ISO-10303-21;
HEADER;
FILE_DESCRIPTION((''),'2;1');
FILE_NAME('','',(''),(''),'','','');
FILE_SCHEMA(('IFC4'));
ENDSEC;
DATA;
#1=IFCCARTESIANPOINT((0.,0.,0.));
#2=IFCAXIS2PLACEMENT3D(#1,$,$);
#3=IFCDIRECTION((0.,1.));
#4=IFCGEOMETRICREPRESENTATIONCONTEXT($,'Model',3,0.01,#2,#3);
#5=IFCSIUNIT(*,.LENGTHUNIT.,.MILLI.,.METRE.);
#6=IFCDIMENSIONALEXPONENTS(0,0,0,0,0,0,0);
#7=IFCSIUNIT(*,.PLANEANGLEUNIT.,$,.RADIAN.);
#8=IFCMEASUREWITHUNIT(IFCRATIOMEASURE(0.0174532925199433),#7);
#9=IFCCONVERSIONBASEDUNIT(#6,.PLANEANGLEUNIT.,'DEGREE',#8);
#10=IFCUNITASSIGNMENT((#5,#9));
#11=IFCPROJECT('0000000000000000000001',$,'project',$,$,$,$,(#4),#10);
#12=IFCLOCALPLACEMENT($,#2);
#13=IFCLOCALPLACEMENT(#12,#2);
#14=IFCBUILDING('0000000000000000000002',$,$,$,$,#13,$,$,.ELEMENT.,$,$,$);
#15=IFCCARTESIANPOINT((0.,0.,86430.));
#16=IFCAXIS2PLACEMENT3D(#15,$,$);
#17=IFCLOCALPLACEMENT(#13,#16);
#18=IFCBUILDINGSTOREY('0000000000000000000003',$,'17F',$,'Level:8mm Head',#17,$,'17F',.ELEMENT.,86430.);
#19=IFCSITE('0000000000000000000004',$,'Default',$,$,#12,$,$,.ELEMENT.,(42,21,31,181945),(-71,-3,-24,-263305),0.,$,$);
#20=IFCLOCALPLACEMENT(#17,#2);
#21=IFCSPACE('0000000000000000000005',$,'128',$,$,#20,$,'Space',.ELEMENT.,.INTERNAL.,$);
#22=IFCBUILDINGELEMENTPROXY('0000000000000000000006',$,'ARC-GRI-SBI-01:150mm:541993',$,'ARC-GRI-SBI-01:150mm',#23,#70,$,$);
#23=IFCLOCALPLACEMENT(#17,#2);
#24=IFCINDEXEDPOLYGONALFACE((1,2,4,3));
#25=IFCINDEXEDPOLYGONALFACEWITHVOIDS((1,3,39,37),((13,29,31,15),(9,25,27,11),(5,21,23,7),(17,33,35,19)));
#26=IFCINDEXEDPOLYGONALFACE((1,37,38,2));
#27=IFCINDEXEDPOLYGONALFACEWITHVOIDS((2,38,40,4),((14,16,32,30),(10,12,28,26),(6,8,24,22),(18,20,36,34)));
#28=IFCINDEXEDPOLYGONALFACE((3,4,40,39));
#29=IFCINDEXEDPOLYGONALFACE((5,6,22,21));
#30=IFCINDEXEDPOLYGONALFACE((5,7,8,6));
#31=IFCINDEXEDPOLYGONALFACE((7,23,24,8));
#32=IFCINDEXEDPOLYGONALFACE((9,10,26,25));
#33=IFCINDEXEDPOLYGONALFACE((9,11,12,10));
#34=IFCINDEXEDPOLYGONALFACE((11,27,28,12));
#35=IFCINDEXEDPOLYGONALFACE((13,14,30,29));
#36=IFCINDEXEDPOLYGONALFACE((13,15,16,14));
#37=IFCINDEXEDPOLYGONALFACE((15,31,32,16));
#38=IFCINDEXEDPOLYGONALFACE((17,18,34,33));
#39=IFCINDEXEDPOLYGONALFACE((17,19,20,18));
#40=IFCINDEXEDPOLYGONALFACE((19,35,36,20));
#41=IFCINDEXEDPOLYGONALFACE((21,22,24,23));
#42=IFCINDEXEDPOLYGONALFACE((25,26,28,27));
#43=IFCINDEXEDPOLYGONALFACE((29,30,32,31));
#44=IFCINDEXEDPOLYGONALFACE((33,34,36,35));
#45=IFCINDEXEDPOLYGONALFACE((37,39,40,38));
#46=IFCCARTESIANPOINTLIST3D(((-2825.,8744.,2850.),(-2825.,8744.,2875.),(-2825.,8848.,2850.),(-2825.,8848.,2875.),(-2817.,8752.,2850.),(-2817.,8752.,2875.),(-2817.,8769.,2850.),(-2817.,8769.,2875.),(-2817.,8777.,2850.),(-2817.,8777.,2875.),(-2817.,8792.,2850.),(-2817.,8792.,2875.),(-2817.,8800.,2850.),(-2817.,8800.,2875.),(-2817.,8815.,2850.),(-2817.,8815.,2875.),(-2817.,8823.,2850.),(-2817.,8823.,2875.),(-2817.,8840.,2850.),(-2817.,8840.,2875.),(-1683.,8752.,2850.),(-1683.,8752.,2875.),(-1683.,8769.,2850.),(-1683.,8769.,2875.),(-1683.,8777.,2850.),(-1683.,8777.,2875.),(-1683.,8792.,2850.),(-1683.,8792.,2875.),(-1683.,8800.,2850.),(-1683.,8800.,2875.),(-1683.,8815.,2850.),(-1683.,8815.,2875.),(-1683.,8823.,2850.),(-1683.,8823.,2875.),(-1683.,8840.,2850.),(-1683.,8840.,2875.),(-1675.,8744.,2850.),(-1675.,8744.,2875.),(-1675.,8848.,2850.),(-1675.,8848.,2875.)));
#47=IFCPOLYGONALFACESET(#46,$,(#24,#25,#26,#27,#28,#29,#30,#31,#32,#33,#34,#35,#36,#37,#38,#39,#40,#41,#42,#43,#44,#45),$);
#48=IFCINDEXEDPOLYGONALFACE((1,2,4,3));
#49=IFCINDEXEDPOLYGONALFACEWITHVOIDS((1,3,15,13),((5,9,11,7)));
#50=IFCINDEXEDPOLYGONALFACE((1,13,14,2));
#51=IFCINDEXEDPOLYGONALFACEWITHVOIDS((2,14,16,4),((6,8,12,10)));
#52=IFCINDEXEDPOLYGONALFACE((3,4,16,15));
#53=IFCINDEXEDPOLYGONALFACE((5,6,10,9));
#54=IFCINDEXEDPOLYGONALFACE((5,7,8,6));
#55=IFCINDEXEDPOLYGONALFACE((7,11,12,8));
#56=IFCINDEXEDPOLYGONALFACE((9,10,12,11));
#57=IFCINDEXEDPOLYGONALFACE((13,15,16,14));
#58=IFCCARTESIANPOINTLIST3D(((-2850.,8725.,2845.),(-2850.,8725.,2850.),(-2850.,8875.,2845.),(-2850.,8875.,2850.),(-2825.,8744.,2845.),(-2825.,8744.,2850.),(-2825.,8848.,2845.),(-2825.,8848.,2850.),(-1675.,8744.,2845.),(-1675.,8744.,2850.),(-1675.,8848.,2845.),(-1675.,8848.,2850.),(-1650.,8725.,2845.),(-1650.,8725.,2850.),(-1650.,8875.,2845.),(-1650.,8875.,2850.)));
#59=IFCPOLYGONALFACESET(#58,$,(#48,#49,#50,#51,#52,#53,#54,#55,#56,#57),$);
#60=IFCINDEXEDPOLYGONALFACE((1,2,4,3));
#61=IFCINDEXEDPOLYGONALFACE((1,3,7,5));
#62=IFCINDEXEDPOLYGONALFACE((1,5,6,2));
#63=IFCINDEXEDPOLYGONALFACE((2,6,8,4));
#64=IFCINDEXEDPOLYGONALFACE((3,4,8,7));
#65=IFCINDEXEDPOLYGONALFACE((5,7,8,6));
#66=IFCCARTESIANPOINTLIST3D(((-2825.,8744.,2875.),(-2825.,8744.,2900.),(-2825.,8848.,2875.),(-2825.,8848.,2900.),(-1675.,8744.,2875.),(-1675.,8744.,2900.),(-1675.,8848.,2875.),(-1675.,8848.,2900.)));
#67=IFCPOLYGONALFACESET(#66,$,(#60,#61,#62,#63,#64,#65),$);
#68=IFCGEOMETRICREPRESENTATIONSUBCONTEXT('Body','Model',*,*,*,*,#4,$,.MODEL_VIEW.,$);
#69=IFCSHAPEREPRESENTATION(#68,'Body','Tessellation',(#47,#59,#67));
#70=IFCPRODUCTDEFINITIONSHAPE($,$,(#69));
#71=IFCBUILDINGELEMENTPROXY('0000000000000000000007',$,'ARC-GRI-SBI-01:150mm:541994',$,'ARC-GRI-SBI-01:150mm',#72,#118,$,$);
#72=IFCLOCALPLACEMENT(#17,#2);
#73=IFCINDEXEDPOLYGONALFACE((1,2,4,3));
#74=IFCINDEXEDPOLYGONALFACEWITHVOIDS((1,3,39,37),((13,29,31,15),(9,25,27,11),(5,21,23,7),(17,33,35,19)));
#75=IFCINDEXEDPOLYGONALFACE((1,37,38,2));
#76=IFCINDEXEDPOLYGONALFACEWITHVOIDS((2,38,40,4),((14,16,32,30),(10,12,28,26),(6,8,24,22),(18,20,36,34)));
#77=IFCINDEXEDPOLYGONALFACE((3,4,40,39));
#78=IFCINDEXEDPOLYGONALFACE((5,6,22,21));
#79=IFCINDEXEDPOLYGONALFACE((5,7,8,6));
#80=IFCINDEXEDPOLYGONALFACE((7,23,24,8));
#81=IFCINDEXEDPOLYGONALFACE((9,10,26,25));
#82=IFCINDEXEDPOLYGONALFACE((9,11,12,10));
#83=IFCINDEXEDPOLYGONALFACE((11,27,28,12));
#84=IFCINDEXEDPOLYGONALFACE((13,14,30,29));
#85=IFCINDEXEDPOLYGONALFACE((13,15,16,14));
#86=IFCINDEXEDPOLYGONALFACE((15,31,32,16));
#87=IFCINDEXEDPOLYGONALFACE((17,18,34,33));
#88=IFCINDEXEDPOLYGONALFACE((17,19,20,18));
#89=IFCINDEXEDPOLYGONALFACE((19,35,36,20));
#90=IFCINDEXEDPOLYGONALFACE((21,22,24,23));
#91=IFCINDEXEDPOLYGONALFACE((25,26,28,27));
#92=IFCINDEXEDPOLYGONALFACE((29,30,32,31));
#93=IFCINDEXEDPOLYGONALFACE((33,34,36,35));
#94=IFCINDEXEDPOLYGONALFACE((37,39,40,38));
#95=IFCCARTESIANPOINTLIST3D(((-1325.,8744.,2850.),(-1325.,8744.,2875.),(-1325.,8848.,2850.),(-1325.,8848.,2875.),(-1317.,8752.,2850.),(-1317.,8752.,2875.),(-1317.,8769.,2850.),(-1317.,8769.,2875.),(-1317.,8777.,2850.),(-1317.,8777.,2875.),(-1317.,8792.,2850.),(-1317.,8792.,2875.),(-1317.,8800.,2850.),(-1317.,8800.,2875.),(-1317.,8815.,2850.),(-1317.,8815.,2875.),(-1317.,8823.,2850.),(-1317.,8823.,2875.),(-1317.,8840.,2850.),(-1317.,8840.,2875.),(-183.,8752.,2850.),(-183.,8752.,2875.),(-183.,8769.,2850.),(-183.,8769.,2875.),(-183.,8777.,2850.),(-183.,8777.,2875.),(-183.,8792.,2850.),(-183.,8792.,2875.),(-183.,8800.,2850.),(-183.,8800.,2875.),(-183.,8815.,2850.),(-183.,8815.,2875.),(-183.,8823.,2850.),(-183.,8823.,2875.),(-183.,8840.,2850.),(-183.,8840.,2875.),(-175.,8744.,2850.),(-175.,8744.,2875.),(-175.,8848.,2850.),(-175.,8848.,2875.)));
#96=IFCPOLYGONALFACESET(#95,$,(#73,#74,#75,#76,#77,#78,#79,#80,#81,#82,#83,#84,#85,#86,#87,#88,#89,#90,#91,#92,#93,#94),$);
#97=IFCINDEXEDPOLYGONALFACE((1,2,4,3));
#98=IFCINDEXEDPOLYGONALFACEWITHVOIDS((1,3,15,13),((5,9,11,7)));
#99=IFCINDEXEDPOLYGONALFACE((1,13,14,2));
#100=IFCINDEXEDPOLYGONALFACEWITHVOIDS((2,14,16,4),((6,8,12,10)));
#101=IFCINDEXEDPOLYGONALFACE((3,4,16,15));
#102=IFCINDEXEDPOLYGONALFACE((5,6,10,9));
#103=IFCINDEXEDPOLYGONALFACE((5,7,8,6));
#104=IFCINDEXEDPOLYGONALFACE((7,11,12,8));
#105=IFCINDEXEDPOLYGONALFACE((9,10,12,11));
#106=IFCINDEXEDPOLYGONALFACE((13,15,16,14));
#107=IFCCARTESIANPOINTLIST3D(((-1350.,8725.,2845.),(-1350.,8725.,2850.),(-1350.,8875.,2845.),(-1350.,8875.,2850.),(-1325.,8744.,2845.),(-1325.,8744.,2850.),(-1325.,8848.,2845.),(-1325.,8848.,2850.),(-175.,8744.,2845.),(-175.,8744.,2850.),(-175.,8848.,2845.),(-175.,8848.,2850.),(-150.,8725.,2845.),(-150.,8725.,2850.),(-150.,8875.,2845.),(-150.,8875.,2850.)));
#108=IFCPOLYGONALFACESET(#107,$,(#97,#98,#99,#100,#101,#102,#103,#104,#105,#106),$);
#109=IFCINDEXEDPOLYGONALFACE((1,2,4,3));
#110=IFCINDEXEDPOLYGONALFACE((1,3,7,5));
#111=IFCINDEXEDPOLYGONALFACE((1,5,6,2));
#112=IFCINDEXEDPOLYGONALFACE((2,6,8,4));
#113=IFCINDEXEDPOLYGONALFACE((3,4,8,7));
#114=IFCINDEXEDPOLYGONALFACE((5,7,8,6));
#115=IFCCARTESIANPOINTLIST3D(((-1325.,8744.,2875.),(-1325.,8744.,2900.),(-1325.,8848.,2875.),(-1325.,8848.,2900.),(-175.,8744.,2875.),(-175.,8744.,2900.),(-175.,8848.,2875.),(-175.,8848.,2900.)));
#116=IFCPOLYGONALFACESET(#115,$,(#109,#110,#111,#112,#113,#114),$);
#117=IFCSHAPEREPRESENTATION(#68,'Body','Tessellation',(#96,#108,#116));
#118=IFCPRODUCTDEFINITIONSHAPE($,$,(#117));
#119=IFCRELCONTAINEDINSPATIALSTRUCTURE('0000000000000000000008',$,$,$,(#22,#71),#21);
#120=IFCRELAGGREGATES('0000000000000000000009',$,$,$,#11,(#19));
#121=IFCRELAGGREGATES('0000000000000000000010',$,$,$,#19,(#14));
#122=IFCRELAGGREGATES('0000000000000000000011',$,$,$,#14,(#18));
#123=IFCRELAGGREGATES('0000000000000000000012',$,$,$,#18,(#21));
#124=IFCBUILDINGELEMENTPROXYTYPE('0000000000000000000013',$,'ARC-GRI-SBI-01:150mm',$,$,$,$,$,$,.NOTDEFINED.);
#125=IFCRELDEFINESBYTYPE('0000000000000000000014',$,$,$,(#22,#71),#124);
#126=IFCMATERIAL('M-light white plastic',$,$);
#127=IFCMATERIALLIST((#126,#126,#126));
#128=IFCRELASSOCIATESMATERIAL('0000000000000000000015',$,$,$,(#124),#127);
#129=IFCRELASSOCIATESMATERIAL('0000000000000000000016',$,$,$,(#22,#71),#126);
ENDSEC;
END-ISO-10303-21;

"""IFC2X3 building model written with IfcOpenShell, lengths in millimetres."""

from ifc_helpers import new_model, entity, si_unit, converted_unit, direction, frame, origin, origin_2d_with_axis, place, context, subcontext, project, spatial, polyline, rectangle, outline, extrude, source, transform, mapped, material, material_list, type_object, type_shapes, element, save


model = new_model("IFC2X3")

# Units and contexts
model_context = context("Model", 3, precision=0.01, world=origin(), true_north=direction((0.0, 1.0)))
body_context = subcontext(model_context, "Body", "Model", "MODEL_VIEW")
ifc_project = project(units=[si_unit("LENGTHUNIT", "METRE", prefix="MILLI"), converted_unit("PLANEANGLEUNIT", "DEGREE", entity("IfcRatioMeasure", 0.0174532925199433), si_unit("PLANEANGLEUNIT", "RADIAN"), dimensions=[0, 0, 0, 0, 0, 0, 0])], contexts=[model_context])

# Site, building, storey
site_placement = place(None, origin())
site = spatial("IfcSite", under=ifc_project, at=site_placement, Name="Default", CompositionType="ELEMENT", RefLatitude=(42, 21, 31, 181945), RefLongitude=(-71, -3, -24, -263305), RefElevation=0.0)
building_placement = place(site_placement, origin())
building = spatial("IfcBuilding", under=site, at=building_placement, CompositionType="ELEMENT")
storey_placement = place(building_placement, frame((0.0, 0.0, 86430.0)))
storey = spatial("IfcBuildingStorey", under=building, at=storey_placement, Name="17F", ObjectType="Level:8mm Head", LongName="17F", CompositionType="ELEMENT", Elevation=86430.0)

# Shared definitions
space_placement = place(storey_placement, origin())
space = spatial("IfcSpace", under=storey, at=space_placement, Name="128", LongName="Space", CompositionType="ELEMENT", InteriorOrExteriorSpace="INTERNAL")

# Building element proxies
ifc_material_1 = material(Name="M-light white plastic")
ifc_material_list = material_list([ifc_material_1, ifc_material_1, ifc_material_1])
building_element_proxy_type = type_object("IfcBuildingElementProxyType", Name="ARC-GRI-SBI-01:150mm", PredefinedType="NOTDEFINED", material=ifc_material_list)
shared_shape = source(origin(), body_context, "Body", "SweptSolid", [
    extrude(outline(polyline([(-575.0, -52.0), (575.0, -52.0), (575.0, 52.0), (-575.0, 52.0), (-575.0, -52.0)]), holes=[polyline([(-567.0, -44.0), (-567.0, -27.0), (567.0, -27.0), (567.0, -44.0), (-567.0, -44.0)]), polyline([(567.0, -4.0), (567.0, -19.0), (-567.0, -19.0), (-567.0, -4.0), (567.0, -4.0)]), polyline([(-567.0, 44.0), (567.0, 44.0), (567.0, 27.0), (-567.0, 27.0), (-567.0, 44.0)]), polyline([(567.0, 4.0), (-567.0, 4.0), (-567.0, 19.0), (567.0, 19.0), (567.0, 4.0)])]), frame((425.0, 4.0, 4000.0), z_axis=(0.0, 0.0, 1.0), x_axis=(-1.0, 0.0, 0.0)), (0.0, 0.0, 1.0), 25.0),
    extrude(outline(polyline([(-600.0, -75.0), (600.0, -75.0), (600.0, 75.0), (-600.0, 75.0), (-600.0, -75.0)]), holes=[polyline([(-575.0, -56.0), (-575.0, 48.0), (575.0, 48.0), (575.0, -56.0), (-575.0, -56.0)])]), frame((425.0, 0.0, 3995.0), z_axis=(0.0, 0.0, 1.0), x_axis=(-1.0, 0.0, 0.0)), (0.0, 0.0, 1.0), 5.0),
    extrude(rectangle(XDim=1150.0, YDim=104.0, at=origin_2d_with_axis()), frame((425.0, 4.0, 4025.0), z_axis=(0.0, 0.0, 1.0), x_axis=(-1.0, 0.0, 0.0)), (0.0, 0.0, 1.0), 25.0),
])
type_shapes(building_element_proxy_type, [shared_shape])
for number, where, z_axis, x_axis, name in (
    (1, (-1825.0, 8800.0, -1150.0), (0.0, 0.0, 1.0), (-1.0, 0.0, 0.0), "ARC-GRI-SBI-01:150mm:541993"),
    (2, (-325.0, 8800.0, -1150.0), (0.0, 0.0, 1.0), (-1.0, 0.0, 0.0), "ARC-GRI-SBI-01:150mm:541994"),
):
    element("IfcBuildingElementProxy", number, at=place(space_placement, frame(where, z_axis=z_axis, x_axis=x_axis)), inside=space, type_object=building_element_proxy_type, material=ifc_material_1, Name=name, ObjectType="ARC-GRI-SBI-01:150mm", context=body_context, shape_type="MappedRepresentation", body=[
        mapped(shared_shape, transform((0.0, 0.0, 0.0), scale=1.0)),
    ])

save(model, "model.ifc")
